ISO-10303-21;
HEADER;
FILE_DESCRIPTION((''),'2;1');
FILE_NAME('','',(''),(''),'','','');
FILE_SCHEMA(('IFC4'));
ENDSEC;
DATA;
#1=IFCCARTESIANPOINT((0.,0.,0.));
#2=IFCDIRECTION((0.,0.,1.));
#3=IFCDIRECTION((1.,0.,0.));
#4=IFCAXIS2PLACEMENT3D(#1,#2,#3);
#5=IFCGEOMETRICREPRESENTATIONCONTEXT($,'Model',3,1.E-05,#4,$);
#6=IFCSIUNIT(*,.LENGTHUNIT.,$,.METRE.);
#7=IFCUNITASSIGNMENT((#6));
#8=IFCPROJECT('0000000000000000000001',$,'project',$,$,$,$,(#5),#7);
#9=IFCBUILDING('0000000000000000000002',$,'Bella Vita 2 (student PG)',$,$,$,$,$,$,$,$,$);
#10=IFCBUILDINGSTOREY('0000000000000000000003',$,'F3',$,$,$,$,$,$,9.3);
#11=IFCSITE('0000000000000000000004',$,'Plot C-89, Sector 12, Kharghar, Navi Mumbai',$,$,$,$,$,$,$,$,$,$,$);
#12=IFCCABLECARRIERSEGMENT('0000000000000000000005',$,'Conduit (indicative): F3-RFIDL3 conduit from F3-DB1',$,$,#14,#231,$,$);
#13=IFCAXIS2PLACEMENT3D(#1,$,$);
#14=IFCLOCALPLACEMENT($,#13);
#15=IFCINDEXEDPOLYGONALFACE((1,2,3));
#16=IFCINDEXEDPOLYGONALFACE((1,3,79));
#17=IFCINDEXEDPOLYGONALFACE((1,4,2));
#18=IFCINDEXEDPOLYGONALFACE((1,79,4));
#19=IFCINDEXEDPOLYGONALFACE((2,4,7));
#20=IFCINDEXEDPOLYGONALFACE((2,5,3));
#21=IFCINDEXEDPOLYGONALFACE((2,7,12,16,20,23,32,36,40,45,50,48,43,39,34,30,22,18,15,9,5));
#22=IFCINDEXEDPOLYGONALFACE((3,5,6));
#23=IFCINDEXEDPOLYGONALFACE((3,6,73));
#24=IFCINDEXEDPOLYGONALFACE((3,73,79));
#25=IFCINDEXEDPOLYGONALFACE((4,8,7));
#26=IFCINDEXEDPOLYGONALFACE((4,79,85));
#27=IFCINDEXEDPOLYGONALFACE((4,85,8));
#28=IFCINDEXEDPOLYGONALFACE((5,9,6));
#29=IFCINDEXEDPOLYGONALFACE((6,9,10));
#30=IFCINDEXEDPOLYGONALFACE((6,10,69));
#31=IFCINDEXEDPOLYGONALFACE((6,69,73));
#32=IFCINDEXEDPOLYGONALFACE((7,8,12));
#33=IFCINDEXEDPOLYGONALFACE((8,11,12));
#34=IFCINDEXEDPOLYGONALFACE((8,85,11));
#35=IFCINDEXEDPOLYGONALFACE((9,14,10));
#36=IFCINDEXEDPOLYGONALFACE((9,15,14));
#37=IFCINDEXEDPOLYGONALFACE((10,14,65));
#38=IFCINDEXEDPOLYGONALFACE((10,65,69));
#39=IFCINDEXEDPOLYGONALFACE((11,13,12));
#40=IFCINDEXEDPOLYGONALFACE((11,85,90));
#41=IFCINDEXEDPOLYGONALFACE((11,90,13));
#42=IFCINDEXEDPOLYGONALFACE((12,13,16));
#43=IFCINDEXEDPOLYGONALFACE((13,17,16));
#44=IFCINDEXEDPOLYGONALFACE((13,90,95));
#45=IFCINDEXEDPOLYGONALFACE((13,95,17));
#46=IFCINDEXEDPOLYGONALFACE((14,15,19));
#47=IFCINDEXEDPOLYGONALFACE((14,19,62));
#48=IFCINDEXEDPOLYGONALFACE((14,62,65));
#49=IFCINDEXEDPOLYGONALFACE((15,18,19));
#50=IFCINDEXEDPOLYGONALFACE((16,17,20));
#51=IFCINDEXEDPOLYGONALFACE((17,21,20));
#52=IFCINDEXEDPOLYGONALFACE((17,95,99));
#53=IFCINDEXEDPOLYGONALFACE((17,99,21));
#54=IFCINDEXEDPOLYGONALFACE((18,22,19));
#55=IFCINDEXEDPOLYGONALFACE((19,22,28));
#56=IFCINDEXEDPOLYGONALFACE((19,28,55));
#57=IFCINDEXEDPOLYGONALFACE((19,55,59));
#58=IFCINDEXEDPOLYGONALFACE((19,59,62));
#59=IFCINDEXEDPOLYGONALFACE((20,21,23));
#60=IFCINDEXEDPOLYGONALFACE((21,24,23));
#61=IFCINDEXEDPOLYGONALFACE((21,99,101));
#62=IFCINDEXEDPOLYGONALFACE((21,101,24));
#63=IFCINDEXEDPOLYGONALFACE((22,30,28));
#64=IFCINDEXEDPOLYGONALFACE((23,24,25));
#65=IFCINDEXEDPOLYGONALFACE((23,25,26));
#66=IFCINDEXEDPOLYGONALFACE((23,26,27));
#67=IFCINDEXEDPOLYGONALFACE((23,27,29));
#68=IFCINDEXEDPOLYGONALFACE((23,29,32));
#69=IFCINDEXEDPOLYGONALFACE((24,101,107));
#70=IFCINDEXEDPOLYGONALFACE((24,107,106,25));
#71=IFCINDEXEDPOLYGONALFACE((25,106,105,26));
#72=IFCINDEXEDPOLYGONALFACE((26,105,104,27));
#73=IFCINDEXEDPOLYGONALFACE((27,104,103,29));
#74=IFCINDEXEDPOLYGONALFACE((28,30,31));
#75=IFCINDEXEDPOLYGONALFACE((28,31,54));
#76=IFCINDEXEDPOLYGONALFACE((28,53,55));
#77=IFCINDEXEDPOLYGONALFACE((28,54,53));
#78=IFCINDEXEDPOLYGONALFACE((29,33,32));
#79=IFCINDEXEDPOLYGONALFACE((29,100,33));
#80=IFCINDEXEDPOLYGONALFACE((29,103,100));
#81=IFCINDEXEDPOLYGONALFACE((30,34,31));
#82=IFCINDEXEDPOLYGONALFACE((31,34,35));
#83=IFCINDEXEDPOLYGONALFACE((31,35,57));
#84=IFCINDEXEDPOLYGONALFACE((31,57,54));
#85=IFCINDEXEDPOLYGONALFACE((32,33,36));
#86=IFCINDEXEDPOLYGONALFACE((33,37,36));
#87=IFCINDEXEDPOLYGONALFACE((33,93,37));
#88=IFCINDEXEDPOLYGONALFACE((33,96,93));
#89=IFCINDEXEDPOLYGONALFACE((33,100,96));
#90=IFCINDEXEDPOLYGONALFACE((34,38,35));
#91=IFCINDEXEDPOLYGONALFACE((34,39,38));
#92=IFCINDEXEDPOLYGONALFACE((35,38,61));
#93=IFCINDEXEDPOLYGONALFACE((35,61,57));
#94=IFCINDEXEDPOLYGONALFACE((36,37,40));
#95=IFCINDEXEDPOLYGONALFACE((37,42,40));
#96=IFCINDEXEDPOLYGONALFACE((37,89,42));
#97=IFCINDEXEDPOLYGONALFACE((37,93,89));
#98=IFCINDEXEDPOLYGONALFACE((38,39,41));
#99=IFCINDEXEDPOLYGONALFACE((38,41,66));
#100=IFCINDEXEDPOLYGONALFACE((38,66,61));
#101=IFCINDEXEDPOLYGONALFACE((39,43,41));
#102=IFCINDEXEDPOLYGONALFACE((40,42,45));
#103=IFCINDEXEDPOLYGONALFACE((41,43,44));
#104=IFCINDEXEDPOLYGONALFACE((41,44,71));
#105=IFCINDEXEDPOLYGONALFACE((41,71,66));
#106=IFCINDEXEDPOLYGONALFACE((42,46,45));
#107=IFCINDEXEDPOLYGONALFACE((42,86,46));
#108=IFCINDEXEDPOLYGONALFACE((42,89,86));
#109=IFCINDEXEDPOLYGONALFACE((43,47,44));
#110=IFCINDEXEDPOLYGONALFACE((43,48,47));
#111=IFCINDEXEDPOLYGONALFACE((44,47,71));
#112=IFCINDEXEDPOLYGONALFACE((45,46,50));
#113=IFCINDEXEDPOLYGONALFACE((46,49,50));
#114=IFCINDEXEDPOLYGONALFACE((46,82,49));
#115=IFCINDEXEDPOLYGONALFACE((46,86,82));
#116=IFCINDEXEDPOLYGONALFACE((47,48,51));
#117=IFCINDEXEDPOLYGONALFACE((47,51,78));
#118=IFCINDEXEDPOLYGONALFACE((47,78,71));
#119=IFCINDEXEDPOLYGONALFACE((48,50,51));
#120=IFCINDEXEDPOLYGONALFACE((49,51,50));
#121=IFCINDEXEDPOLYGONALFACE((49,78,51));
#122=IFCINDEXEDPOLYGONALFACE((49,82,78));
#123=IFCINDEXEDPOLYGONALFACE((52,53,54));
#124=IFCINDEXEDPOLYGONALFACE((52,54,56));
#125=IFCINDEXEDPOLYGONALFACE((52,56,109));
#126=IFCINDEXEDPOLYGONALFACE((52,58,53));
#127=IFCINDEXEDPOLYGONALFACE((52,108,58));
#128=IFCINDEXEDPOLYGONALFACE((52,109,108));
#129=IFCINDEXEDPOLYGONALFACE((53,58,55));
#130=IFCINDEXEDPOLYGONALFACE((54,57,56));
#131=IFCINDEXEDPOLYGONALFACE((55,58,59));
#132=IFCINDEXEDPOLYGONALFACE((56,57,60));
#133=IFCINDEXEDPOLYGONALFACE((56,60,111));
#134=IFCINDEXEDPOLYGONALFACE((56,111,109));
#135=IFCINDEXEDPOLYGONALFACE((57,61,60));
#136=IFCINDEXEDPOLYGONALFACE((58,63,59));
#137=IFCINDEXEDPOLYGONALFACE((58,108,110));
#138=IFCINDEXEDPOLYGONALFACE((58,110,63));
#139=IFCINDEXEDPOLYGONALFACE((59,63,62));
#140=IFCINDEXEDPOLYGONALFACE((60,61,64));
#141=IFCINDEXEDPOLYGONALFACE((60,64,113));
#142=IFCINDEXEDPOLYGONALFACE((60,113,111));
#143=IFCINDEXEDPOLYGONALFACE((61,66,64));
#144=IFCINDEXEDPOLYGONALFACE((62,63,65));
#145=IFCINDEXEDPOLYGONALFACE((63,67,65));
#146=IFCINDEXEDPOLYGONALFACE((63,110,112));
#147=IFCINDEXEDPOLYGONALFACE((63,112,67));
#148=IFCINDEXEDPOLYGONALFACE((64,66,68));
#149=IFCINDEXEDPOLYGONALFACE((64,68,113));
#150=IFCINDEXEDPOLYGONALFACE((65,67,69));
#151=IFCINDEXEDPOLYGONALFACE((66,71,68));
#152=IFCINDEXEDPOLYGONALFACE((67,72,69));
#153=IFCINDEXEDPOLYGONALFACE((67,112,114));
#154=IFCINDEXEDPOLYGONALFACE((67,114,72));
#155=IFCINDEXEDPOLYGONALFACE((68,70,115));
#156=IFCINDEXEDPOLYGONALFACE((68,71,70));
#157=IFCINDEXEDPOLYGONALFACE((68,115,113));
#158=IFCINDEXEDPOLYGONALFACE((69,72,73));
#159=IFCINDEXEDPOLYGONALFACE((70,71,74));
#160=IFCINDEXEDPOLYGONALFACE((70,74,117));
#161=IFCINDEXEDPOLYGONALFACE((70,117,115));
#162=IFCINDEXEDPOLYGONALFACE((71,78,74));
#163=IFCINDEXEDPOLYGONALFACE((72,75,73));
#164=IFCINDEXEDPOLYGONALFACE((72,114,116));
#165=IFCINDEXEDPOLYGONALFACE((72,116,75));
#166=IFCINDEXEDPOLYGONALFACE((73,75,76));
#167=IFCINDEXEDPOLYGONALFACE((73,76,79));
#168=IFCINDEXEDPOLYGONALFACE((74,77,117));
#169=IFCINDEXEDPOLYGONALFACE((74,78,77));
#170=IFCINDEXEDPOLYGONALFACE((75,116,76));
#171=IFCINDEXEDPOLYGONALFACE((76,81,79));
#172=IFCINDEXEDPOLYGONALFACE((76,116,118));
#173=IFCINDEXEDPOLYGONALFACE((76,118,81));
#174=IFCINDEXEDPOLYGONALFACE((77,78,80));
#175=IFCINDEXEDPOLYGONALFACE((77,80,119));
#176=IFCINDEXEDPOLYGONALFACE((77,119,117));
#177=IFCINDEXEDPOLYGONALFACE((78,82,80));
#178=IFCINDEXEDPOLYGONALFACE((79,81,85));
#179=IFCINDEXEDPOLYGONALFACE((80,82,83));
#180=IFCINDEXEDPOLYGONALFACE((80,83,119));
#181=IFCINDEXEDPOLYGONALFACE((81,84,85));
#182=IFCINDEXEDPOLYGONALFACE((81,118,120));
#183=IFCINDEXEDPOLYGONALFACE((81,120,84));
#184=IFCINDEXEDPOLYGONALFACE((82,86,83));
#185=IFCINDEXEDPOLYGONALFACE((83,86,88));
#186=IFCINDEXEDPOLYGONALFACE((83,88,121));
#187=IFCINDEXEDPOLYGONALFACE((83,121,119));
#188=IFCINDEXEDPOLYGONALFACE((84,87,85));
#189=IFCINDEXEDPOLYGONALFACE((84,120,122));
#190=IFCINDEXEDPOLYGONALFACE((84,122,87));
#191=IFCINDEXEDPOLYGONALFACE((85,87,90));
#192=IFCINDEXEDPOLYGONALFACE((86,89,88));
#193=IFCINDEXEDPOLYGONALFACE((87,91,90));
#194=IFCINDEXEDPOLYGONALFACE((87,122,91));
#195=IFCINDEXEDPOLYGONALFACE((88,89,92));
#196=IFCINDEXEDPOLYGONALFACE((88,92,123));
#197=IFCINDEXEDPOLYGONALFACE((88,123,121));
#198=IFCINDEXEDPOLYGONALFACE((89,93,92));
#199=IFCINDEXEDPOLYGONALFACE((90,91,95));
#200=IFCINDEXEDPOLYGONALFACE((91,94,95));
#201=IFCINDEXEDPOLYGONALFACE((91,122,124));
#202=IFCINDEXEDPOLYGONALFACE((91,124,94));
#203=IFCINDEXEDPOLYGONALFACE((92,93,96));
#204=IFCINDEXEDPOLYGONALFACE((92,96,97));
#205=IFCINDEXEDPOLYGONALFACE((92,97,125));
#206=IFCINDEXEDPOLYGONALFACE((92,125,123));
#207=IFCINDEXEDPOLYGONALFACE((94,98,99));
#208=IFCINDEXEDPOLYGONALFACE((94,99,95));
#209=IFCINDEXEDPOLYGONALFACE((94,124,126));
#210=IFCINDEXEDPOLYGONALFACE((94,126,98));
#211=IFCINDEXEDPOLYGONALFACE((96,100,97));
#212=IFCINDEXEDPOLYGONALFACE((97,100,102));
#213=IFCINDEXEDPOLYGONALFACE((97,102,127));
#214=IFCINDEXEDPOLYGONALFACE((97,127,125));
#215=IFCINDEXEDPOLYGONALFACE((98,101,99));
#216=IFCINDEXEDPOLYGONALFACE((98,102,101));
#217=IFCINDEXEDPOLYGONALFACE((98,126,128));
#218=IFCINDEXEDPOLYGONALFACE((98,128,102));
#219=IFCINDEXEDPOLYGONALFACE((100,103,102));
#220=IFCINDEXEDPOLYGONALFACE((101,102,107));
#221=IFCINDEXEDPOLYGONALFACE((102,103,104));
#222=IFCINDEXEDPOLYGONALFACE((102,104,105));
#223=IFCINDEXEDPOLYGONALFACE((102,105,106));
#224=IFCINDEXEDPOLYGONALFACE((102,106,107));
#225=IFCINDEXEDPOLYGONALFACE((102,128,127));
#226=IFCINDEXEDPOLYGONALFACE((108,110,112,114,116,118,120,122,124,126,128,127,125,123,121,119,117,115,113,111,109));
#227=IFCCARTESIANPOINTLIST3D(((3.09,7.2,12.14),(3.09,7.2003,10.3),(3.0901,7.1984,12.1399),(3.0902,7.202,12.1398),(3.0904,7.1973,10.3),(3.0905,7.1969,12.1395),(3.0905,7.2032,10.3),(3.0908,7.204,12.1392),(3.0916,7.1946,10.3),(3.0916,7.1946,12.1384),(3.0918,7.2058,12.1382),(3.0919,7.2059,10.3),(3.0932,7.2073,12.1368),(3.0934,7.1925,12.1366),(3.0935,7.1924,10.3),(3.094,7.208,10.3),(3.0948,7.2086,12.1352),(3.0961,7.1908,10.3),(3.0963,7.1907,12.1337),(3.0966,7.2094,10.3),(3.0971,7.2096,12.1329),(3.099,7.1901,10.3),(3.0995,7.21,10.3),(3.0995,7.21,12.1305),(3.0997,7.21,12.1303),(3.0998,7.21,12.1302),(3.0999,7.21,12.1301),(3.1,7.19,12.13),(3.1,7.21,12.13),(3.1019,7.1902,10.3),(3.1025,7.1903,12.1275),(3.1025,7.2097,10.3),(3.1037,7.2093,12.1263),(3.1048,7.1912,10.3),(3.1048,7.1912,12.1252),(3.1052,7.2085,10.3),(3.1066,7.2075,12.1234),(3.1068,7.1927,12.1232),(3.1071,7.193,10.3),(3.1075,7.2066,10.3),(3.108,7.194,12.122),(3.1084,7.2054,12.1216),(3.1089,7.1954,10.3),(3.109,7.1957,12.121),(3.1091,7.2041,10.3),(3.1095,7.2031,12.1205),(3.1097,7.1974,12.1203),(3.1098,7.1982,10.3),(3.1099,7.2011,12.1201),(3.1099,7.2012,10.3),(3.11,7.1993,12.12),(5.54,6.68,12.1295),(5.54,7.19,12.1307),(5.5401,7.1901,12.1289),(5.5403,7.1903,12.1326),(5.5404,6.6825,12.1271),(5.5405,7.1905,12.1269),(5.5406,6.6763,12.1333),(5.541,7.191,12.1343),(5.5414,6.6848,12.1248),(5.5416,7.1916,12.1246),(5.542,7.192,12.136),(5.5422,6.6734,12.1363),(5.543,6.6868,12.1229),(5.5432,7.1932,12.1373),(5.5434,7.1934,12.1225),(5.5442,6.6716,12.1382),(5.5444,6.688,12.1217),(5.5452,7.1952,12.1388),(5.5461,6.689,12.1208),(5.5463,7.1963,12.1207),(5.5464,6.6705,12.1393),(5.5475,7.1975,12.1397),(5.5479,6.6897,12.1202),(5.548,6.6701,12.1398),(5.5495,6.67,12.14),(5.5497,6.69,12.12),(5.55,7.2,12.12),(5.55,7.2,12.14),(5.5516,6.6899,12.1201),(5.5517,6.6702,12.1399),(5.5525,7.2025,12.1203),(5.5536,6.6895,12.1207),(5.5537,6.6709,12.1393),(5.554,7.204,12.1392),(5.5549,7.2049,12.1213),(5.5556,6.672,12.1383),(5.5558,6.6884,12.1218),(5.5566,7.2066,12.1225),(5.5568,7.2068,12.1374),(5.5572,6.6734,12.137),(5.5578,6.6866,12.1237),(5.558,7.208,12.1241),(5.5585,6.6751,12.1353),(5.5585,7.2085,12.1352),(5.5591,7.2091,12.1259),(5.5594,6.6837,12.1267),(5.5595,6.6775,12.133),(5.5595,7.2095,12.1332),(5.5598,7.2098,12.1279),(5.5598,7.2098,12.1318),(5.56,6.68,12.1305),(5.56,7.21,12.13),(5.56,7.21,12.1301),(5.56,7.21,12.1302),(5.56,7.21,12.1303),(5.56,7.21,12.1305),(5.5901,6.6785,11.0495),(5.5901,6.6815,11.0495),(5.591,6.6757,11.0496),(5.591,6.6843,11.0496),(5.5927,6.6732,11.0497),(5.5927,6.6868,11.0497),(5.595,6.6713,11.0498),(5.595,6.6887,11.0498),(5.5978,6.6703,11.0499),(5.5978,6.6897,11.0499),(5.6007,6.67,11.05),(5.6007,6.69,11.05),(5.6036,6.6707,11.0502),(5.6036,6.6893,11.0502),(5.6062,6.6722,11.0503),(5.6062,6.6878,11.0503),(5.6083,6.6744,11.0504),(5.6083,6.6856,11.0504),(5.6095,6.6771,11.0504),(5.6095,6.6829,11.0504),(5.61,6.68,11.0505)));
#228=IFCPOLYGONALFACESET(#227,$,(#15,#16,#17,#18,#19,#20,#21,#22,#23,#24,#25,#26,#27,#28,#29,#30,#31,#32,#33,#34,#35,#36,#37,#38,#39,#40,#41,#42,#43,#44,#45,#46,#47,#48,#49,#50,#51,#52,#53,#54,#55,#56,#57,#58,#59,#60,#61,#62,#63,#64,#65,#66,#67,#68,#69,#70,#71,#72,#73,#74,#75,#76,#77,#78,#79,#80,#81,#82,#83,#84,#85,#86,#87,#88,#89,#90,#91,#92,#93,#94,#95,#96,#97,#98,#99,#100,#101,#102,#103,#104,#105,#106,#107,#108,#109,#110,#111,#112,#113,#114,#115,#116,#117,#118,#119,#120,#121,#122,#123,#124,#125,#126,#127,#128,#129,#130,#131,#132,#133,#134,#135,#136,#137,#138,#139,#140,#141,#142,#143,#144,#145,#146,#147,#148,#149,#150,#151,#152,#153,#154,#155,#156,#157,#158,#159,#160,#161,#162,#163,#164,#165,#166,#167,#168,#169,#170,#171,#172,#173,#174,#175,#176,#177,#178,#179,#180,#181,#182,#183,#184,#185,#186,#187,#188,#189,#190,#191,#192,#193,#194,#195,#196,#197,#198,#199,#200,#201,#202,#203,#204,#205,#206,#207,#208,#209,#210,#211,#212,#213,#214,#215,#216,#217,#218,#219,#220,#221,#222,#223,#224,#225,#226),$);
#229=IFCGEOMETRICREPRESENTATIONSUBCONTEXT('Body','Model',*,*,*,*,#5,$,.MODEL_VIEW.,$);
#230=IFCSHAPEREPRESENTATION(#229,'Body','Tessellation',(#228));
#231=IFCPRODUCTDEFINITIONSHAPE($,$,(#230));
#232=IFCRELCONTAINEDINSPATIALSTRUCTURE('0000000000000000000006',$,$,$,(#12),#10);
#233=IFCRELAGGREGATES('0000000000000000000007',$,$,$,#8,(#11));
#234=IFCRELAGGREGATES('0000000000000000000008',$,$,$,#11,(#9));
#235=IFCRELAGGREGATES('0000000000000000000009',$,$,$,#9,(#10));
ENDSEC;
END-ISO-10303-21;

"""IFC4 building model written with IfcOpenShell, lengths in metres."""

from ifc_helpers import new_model, entity, si_unit, origin, origin_with_axes, place, context, subcontext, project, spatial, element, save


model = new_model("IFC4")

# Units and contexts
model_context = context("Model", 3, precision=1e-05, world=origin_with_axes())
body_context = subcontext(model_context, "Body", "Model", "MODEL_VIEW")
ifc_project = project(units=[si_unit("LENGTHUNIT", "METRE")], contexts=[model_context])

# Site, building, storey
site = spatial("IfcSite", under=ifc_project, Name="Plot C-89, Sector 12, Kharghar, Navi Mumbai")
building = spatial("IfcBuilding", under=site, Name="Bella Vita 2 (student PG)")
storey = spatial("IfcBuildingStorey", under=building, Name="F3", Elevation=9.3)

# Cable carrier segment
cable_carrier_segment_1_placement = place(None, origin())
element("IfcCableCarrierSegment", 1, at=cable_carrier_segment_1_placement, inside=storey, Name="Conduit (indicative): F3-RFIDL3 conduit from F3-DB1", context=body_context, shape_type="AdvancedSweptSolid", body=[
    entity("IfcSweptDiskSolid", entity("IfcPolyline", [entity("IfcCartesianPoint", [5.6, 6.68, 11.05]), entity("IfcCartesianPoint", [5.55, 6.68, 12.13]), entity("IfcCartesianPoint", [5.55, 7.2, 12.13]), entity("IfcCartesianPoint", [3.1, 7.2, 12.13]), entity("IfcCartesianPoint", [3.1, 7.2, 10.3])]), 0.01),
])

save(model, "model.ifc")
